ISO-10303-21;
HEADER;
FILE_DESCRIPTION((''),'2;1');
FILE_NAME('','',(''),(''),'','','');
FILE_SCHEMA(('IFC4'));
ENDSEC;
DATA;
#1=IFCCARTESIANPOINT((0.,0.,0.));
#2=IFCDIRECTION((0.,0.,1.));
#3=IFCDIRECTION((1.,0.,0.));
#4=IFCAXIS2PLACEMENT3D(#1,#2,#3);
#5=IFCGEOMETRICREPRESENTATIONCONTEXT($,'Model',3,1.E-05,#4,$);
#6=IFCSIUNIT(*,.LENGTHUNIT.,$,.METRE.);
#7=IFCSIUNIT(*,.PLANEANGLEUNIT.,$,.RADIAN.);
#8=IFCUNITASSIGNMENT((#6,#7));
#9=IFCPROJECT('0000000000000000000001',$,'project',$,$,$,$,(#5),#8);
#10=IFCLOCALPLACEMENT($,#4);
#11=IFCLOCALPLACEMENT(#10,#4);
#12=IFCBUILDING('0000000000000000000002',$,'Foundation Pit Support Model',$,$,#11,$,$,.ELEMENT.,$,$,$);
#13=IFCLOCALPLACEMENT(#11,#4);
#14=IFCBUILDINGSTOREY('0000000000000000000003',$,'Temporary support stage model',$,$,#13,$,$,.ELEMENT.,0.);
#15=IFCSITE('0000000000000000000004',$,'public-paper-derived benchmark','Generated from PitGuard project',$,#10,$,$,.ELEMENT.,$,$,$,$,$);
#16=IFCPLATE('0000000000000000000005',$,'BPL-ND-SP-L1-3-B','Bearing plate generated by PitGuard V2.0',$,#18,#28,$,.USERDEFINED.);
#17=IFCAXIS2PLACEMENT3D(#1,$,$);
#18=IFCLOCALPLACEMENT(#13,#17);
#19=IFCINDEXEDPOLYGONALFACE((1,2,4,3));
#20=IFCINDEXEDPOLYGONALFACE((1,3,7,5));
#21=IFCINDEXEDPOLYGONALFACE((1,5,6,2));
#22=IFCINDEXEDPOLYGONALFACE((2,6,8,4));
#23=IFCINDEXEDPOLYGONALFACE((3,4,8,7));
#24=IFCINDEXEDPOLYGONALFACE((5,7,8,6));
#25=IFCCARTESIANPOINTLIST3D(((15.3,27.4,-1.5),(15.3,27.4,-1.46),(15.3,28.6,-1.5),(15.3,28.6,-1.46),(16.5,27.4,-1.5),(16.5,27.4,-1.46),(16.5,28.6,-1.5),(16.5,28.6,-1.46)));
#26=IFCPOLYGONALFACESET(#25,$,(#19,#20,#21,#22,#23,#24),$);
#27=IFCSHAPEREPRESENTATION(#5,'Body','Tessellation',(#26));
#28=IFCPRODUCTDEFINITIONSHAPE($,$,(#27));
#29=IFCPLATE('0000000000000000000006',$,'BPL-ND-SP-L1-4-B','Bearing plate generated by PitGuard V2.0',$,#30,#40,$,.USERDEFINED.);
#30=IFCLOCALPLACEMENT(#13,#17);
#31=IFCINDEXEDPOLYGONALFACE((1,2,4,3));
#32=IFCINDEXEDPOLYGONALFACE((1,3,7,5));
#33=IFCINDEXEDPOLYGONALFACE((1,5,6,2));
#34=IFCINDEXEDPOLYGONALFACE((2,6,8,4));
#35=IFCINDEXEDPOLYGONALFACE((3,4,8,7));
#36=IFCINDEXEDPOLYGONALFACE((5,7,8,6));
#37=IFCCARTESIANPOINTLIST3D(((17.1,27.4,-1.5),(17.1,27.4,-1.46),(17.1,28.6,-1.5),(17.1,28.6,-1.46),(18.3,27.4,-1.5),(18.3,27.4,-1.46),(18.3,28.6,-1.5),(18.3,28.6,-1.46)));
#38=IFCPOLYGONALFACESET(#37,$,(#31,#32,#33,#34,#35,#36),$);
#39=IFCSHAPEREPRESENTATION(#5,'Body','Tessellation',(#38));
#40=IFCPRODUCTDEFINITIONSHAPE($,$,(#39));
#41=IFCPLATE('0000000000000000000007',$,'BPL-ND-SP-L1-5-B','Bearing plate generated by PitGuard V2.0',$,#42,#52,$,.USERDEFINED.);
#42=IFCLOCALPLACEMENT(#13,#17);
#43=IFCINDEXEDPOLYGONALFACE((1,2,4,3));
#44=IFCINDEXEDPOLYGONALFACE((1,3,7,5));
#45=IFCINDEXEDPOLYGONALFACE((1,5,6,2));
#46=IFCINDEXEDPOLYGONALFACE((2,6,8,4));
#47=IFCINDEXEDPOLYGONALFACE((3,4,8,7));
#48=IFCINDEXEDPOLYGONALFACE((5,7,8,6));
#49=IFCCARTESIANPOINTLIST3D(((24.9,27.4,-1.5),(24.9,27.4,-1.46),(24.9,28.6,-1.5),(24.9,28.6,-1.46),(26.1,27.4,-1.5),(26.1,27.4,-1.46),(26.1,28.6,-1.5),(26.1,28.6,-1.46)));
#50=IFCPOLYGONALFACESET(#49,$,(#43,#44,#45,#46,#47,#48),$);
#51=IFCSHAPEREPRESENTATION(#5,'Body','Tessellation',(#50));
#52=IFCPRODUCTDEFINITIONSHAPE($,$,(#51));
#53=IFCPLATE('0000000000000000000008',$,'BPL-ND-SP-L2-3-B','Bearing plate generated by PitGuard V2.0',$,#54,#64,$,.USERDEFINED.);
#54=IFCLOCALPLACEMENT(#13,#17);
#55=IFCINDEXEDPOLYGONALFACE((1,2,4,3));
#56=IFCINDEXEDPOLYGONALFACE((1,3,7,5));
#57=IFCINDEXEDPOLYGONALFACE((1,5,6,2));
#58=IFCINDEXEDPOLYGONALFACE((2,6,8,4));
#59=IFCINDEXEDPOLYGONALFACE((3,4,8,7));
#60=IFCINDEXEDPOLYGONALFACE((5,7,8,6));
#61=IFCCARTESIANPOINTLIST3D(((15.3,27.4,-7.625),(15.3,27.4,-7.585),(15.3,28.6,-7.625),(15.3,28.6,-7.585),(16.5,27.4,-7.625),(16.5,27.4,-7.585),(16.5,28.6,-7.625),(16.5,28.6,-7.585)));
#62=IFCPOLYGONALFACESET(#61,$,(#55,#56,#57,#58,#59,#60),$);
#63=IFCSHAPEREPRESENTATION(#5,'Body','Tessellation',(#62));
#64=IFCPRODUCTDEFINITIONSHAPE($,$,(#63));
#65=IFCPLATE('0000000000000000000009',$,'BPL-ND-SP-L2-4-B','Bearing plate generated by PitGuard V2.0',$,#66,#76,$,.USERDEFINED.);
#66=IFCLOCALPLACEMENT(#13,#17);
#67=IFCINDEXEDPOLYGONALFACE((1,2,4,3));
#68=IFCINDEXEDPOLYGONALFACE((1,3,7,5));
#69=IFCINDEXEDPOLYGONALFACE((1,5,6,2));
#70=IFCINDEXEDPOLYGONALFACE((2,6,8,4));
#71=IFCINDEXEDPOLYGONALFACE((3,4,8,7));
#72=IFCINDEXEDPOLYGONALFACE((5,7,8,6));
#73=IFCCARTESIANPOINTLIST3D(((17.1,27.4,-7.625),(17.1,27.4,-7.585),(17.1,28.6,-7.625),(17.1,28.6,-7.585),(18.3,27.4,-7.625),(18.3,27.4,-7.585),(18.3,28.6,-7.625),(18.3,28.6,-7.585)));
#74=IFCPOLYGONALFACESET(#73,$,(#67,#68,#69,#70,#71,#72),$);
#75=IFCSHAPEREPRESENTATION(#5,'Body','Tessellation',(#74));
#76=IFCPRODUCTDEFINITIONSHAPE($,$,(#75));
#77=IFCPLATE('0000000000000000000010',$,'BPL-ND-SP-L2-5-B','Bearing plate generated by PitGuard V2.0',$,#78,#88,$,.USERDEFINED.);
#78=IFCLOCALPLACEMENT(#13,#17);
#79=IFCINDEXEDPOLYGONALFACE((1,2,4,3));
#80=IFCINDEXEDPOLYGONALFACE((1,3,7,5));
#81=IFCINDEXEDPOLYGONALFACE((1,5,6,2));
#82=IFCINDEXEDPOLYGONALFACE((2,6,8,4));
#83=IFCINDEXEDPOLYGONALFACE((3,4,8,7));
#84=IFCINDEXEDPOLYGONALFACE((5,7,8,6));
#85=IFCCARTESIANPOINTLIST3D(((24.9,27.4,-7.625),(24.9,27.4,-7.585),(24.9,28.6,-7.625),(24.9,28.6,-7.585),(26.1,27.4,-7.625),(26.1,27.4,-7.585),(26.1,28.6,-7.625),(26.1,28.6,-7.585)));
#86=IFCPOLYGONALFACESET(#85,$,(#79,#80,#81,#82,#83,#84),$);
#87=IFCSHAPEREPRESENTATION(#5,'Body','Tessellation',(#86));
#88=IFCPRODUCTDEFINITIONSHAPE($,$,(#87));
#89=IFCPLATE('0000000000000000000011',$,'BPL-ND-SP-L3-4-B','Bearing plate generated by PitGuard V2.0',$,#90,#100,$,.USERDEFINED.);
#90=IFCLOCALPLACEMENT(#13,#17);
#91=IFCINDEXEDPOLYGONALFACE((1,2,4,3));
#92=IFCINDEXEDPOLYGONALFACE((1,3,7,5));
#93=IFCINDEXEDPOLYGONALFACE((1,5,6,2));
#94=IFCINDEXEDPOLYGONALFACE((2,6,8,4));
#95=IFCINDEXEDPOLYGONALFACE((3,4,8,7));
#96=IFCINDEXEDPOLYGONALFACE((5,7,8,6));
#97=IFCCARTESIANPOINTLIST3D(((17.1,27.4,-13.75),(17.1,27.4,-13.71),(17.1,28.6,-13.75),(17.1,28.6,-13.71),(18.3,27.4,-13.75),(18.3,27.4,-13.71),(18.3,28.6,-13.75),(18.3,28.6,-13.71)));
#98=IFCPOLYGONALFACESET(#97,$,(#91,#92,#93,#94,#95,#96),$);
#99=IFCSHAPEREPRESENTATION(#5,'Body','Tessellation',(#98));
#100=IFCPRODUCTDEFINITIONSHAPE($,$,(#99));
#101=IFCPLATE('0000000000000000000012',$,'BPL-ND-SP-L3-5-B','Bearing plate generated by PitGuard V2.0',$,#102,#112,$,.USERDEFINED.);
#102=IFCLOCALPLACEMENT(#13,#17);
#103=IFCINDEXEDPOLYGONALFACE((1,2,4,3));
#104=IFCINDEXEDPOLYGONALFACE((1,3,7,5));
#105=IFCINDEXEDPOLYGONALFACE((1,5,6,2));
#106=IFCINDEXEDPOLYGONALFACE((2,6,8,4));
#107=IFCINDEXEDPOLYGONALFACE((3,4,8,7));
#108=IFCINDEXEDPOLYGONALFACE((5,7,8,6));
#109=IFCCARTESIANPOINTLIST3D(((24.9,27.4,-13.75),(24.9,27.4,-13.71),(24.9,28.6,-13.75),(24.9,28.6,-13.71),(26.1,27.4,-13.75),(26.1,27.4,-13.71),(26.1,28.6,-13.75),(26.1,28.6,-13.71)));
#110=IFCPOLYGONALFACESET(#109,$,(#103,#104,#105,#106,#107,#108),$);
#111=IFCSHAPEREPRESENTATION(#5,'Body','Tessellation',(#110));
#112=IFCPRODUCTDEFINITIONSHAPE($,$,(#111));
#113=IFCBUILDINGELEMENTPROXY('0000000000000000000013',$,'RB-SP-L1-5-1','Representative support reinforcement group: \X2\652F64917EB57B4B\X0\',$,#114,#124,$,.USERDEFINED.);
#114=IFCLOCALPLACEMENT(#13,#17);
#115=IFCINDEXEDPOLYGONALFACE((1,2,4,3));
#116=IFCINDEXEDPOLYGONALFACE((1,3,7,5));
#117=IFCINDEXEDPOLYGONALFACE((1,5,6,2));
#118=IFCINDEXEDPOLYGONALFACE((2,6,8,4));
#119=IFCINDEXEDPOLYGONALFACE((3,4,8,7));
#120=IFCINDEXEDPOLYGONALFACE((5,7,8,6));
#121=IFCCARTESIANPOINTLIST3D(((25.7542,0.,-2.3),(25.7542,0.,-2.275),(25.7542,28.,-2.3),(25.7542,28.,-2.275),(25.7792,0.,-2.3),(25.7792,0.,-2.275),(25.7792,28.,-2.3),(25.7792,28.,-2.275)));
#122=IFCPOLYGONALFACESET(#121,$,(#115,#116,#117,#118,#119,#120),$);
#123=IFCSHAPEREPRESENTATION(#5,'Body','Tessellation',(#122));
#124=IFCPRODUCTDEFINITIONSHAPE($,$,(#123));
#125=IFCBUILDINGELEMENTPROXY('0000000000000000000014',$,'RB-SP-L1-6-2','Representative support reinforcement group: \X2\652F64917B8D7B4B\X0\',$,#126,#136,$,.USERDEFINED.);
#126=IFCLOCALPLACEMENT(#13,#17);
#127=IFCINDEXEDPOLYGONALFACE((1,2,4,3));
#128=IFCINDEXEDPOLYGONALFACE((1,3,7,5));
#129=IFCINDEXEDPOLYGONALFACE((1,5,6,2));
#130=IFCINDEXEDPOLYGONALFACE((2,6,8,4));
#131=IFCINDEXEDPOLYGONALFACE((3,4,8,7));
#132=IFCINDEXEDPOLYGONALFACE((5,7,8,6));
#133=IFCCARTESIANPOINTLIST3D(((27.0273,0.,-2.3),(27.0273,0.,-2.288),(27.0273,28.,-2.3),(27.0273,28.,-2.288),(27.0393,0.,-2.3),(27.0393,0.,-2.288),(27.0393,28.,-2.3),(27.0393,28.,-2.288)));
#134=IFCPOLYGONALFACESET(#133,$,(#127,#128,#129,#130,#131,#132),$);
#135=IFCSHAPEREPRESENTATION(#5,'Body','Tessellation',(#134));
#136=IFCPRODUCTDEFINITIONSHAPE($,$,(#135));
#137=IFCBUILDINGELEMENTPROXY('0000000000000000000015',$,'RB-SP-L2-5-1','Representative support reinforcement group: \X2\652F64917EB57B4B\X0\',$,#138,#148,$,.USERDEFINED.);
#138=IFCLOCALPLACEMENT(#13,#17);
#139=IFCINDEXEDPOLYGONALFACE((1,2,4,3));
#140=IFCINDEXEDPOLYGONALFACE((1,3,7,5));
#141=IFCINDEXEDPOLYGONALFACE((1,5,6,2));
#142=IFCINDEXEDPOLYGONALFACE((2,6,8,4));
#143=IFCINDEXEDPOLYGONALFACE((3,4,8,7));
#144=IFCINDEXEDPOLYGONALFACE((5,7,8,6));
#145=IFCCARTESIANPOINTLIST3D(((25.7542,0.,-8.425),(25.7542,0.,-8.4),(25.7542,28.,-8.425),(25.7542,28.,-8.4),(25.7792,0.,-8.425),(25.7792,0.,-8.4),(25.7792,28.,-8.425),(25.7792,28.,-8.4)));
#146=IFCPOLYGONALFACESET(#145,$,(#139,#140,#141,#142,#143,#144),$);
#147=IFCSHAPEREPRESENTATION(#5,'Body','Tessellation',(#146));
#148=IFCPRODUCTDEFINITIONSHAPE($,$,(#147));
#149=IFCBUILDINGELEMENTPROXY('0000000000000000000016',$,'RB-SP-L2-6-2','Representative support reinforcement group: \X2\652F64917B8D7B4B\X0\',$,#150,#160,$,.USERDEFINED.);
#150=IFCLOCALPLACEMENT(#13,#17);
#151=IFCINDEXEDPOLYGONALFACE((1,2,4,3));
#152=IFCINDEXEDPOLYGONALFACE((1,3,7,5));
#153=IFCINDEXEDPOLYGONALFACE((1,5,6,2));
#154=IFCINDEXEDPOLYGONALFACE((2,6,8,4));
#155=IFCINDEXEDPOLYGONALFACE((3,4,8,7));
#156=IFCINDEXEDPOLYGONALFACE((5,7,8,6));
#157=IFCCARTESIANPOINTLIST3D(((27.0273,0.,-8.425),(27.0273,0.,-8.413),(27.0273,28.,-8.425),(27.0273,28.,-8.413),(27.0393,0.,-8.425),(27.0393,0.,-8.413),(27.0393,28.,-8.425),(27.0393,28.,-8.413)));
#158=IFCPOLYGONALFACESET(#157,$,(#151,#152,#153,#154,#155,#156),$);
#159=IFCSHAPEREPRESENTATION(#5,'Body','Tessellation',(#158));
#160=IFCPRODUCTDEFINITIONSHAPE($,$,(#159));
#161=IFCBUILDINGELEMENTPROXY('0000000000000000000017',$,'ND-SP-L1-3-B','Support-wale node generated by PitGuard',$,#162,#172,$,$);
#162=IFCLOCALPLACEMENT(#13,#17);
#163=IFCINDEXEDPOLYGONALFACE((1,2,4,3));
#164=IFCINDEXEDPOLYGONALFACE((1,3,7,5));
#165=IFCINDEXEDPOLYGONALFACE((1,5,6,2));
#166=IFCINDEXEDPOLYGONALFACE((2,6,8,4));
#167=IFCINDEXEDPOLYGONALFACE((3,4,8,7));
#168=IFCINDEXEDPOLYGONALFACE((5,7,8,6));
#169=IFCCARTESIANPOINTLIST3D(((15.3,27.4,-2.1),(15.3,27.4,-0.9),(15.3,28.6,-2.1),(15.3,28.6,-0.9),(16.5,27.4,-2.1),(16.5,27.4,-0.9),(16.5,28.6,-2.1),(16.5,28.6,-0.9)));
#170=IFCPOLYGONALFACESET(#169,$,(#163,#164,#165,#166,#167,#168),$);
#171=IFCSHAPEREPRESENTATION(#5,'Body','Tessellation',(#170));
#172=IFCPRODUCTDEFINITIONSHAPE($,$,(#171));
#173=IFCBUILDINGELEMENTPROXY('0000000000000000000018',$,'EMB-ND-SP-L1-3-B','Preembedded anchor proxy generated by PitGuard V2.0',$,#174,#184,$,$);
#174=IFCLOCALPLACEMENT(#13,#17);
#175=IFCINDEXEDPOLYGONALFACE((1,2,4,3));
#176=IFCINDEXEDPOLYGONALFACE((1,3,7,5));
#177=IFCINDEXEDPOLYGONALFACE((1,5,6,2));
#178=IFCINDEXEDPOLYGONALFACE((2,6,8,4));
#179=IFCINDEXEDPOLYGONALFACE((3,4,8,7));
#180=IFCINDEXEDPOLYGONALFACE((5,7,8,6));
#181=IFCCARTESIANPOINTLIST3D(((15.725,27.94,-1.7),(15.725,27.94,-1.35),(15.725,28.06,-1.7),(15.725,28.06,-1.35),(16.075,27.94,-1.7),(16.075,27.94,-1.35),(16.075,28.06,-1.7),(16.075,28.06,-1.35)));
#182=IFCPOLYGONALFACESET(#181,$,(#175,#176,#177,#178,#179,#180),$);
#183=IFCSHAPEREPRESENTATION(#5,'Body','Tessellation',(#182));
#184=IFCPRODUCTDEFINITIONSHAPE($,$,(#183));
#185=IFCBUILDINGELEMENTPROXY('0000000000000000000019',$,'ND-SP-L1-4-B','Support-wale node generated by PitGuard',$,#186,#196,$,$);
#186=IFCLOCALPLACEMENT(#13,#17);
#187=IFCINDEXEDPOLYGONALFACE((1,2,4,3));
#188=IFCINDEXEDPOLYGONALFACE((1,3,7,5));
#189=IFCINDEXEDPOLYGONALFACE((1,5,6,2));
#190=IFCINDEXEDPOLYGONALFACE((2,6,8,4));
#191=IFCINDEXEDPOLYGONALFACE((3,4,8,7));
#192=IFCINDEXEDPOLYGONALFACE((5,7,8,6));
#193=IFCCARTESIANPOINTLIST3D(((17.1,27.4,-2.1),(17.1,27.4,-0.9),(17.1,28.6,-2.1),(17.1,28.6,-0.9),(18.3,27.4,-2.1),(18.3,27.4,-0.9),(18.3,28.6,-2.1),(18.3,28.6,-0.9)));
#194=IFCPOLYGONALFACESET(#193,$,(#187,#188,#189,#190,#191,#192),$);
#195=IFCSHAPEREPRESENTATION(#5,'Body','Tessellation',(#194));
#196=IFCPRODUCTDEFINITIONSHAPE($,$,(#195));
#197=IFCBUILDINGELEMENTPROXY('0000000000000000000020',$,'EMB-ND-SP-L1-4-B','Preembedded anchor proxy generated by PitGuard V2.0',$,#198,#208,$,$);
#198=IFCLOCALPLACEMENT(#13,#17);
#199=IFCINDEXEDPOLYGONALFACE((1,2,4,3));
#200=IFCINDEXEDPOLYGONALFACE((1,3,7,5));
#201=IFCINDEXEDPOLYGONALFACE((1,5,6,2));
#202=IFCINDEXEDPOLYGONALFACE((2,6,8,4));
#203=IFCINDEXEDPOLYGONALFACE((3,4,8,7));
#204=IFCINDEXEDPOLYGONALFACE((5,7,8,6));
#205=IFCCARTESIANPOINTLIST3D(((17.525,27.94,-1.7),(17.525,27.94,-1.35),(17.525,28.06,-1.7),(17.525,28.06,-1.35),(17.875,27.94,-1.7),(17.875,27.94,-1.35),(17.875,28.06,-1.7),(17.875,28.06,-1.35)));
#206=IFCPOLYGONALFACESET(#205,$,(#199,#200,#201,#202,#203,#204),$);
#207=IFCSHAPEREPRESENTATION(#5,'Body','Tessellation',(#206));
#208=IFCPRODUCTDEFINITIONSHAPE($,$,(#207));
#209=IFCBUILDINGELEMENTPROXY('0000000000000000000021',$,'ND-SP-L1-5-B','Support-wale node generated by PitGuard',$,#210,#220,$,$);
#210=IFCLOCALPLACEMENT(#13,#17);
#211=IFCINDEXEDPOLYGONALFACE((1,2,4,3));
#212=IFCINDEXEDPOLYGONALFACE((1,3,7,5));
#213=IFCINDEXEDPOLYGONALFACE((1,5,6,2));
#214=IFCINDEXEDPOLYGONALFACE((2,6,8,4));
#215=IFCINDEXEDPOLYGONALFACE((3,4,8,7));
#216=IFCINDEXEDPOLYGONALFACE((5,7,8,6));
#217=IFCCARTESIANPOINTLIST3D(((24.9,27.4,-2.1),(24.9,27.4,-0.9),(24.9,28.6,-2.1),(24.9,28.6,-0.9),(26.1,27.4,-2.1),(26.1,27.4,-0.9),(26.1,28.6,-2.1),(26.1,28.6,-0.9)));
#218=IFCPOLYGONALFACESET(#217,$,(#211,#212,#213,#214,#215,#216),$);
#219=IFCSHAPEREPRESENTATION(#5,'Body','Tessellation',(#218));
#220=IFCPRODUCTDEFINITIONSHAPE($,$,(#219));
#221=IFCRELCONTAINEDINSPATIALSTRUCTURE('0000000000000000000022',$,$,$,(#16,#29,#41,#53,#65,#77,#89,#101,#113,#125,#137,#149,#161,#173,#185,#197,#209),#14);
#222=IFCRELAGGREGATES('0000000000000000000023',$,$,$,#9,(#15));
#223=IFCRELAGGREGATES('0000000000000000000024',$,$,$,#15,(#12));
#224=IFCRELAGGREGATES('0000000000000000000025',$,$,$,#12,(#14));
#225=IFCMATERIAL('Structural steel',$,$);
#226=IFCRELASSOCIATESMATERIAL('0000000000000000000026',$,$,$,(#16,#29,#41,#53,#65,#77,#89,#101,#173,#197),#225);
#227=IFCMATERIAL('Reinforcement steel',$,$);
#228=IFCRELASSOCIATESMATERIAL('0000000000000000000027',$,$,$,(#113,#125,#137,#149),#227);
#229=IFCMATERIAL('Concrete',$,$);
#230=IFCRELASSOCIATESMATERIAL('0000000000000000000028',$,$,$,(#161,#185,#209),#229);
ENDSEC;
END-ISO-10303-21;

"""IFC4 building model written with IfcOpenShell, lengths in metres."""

from ifc_helpers import new_model, si_unit, frame, origin_with_axes, origin_2d, place, context, project, spatial, rectangle, extrude, material, element, save


model = new_model("IFC4")

# Units and contexts
model_context = context("Model", 3, precision=1e-05, world=origin_with_axes())
ifc_project = project(units=[si_unit("LENGTHUNIT", "METRE"), si_unit("PLANEANGLEUNIT", "RADIAN")], contexts=[model_context])

# Site, building, storey
site_placement = place(None, origin_with_axes())
site = spatial("IfcSite", under=ifc_project, at=site_placement, Name="public-paper-derived benchmark", Description="Generated from PitGuard project", CompositionType="ELEMENT")
building_placement = place(site_placement, origin_with_axes())
building = spatial("IfcBuilding", under=site, at=building_placement, Name="Foundation Pit Support Model", CompositionType="ELEMENT")
storey_placement = place(building_placement, origin_with_axes())
storey = spatial("IfcBuildingStorey", under=building, at=storey_placement, Name="Temporary support stage model", CompositionType="ELEMENT", Elevation=0.0)

# Plates
ifc_material_1 = material(Name="Structural steel")
for number, where, z_axis, x_axis, name in (
    (1, (15.9, 28.0, -1.5), (0.0, 0.0, 1.0), (1.0, 0.0, 0.0), "BPL-ND-SP-L1-3-B"),
    (2, (17.7, 28.0, -1.5), (0.0, 0.0, 1.0), (1.0, 0.0, 0.0), "BPL-ND-SP-L1-4-B"),
    (3, (25.5, 28.0, -1.5), (0.0, 0.0, 1.0), (1.0, 0.0, 0.0), "BPL-ND-SP-L1-5-B"),
    (4, (15.9, 28.0, -7.625), (0.0, 0.0, 1.0), (1.0, 0.0, 0.0), "BPL-ND-SP-L2-3-B"),
    (5, (17.7, 28.0, -7.625), (0.0, 0.0, 1.0), (1.0, 0.0, 0.0), "BPL-ND-SP-L2-4-B"),
    (6, (25.5, 28.0, -7.625), (0.0, 0.0, 1.0), (1.0, 0.0, 0.0), "BPL-ND-SP-L2-5-B"),
    (7, (17.7, 28.0, -13.75), (0.0, 0.0, 1.0), (1.0, 0.0, 0.0), "BPL-ND-SP-L3-4-B"),
    (8, (25.5, 28.0, -13.75), (0.0, 0.0, 1.0), (1.0, 0.0, 0.0), "BPL-ND-SP-L3-5-B"),
):
    element("IfcPlate", number, at=place(storey_placement, frame(where, z_axis=z_axis, x_axis=x_axis)), inside=storey, material=ifc_material_1, Name=name, Description="Bearing plate generated by PitGuard V2.0", PredefinedType="USERDEFINED", context=model_context, shape_type="SweptSolid", body=[
        extrude(rectangle(XDim=1.2, YDim=1.2, at=origin_2d()), origin_with_axes(), (0.0, 0.0, 1.0), 0.04),
    ])

# Building element proxies
ifc_material_2 = material(Name="Reinforcement steel")
proxy_1_placement = place(storey_placement, frame((25.7667, 14.0, -2.3), z_axis=(0.0, 0.0, 1.0), x_axis=(0.0, 1.0, 0.0)))
element("IfcBuildingElementProxy", 9, at=proxy_1_placement, inside=storey, material=ifc_material_2, Name="RB-SP-L1-5-1", Description="Representative support reinforcement group: 支撑纵筋", PredefinedType="USERDEFINED", context=model_context, shape_type="SweptSolid", body=[
    extrude(rectangle(XDim=28.0, YDim=0.025, at=origin_2d()), origin_with_axes(), (0.0, 0.0, 1.0), 0.025),
])
proxy_2_placement = place(storey_placement, frame((27.0333, 14.0, -2.3), z_axis=(0.0, 0.0, 1.0), x_axis=(0.0, 1.0, 0.0)))
element("IfcBuildingElementProxy", 10, at=proxy_2_placement, inside=storey, material=ifc_material_2, Name="RB-SP-L1-6-2", Description="Representative support reinforcement group: 支撑箍筋", PredefinedType="USERDEFINED", context=model_context, shape_type="SweptSolid", body=[
    extrude(rectangle(XDim=28.0, YDim=0.012, at=origin_2d()), origin_with_axes(), (0.0, 0.0, 1.0), 0.012),
])
proxy_3_placement = place(storey_placement, frame((25.7667, 14.0, -8.425), z_axis=(0.0, 0.0, 1.0), x_axis=(0.0, 1.0, 0.0)))
element("IfcBuildingElementProxy", 11, at=proxy_3_placement, inside=storey, material=ifc_material_2, Name="RB-SP-L2-5-1", Description="Representative support reinforcement group: 支撑纵筋", PredefinedType="USERDEFINED", context=model_context, shape_type="SweptSolid", body=[
    extrude(rectangle(XDim=28.0, YDim=0.025, at=origin_2d()), origin_with_axes(), (0.0, 0.0, 1.0), 0.025),
])
proxy_4_placement = place(storey_placement, frame((27.0333, 14.0, -8.425), z_axis=(0.0, 0.0, 1.0), x_axis=(0.0, 1.0, 0.0)))
element("IfcBuildingElementProxy", 12, at=proxy_4_placement, inside=storey, material=ifc_material_2, Name="RB-SP-L2-6-2", Description="Representative support reinforcement group: 支撑箍筋", PredefinedType="USERDEFINED", context=model_context, shape_type="SweptSolid", body=[
    extrude(rectangle(XDim=28.0, YDim=0.012, at=origin_2d()), origin_with_axes(), (0.0, 0.0, 1.0), 0.012),
])
ifc_material_3 = material(Name="Concrete")
proxy_5_placement = place(storey_placement, frame((15.9, 28.0, -2.1), z_axis=(0.0, 0.0, 1.0), x_axis=(1.0, 0.0, 0.0)))
element("IfcBuildingElementProxy", 13, at=proxy_5_placement, inside=storey, material=ifc_material_3, Name="ND-SP-L1-3-B", Description="Support-wale node generated by PitGuard", context=model_context, shape_type="SweptSolid", body=[
    extrude(rectangle(XDim=1.2, YDim=1.2, at=origin_2d()), origin_with_axes(), (0.0, 0.0, 1.0), 1.2),
])
proxy_6_placement = place(storey_placement, frame((15.9, 28.0, -1.7), z_axis=(0.0, 0.0, 1.0), x_axis=(1.0, 0.0, 0.0)))
element("IfcBuildingElementProxy", 14, at=proxy_6_placement, inside=storey, material=ifc_material_1, Name="EMB-ND-SP-L1-3-B", Description="Preembedded anchor proxy generated by PitGuard V2.0", context=model_context, shape_type="SweptSolid", body=[
    extrude(rectangle(XDim=0.35, YDim=0.12, at=origin_2d()), origin_with_axes(), (0.0, 0.0, 1.0), 0.35),
])
proxy_7_placement = place(storey_placement, frame((17.7, 28.0, -2.1), z_axis=(0.0, 0.0, 1.0), x_axis=(1.0, 0.0, 0.0)))
element("IfcBuildingElementProxy", 15, at=proxy_7_placement, inside=storey, material=ifc_material_3, Name="ND-SP-L1-4-B", Description="Support-wale node generated by PitGuard", context=model_context, shape_type="SweptSolid", body=[
    extrude(rectangle(XDim=1.2, YDim=1.2, at=origin_2d()), origin_with_axes(), (0.0, 0.0, 1.0), 1.2),
])
proxy_8_placement = place(storey_placement, frame((17.7, 28.0, -1.7), z_axis=(0.0, 0.0, 1.0), x_axis=(1.0, 0.0, 0.0)))
element("IfcBuildingElementProxy", 16, at=proxy_8_placement, inside=storey, material=ifc_material_1, Name="EMB-ND-SP-L1-4-B", Description="Preembedded anchor proxy generated by PitGuard V2.0", context=model_context, shape_type="SweptSolid", body=[
    extrude(rectangle(XDim=0.35, YDim=0.12, at=origin_2d()), origin_with_axes(), (0.0, 0.0, 1.0), 0.35),
])
proxy_9_placement = place(storey_placement, frame((25.5, 28.0, -2.1), z_axis=(0.0, 0.0, 1.0), x_axis=(1.0, 0.0, 0.0)))
element("IfcBuildingElementProxy", 17, at=proxy_9_placement, inside=storey, material=ifc_material_3, Name="ND-SP-L1-5-B", Description="Support-wale node generated by PitGuard", context=model_context, shape_type="SweptSolid", body=[
    extrude(rectangle(XDim=1.2, YDim=1.2, at=origin_2d()), origin_with_axes(), (0.0, 0.0, 1.0), 1.2),
])

save(model, "model.ifc")
